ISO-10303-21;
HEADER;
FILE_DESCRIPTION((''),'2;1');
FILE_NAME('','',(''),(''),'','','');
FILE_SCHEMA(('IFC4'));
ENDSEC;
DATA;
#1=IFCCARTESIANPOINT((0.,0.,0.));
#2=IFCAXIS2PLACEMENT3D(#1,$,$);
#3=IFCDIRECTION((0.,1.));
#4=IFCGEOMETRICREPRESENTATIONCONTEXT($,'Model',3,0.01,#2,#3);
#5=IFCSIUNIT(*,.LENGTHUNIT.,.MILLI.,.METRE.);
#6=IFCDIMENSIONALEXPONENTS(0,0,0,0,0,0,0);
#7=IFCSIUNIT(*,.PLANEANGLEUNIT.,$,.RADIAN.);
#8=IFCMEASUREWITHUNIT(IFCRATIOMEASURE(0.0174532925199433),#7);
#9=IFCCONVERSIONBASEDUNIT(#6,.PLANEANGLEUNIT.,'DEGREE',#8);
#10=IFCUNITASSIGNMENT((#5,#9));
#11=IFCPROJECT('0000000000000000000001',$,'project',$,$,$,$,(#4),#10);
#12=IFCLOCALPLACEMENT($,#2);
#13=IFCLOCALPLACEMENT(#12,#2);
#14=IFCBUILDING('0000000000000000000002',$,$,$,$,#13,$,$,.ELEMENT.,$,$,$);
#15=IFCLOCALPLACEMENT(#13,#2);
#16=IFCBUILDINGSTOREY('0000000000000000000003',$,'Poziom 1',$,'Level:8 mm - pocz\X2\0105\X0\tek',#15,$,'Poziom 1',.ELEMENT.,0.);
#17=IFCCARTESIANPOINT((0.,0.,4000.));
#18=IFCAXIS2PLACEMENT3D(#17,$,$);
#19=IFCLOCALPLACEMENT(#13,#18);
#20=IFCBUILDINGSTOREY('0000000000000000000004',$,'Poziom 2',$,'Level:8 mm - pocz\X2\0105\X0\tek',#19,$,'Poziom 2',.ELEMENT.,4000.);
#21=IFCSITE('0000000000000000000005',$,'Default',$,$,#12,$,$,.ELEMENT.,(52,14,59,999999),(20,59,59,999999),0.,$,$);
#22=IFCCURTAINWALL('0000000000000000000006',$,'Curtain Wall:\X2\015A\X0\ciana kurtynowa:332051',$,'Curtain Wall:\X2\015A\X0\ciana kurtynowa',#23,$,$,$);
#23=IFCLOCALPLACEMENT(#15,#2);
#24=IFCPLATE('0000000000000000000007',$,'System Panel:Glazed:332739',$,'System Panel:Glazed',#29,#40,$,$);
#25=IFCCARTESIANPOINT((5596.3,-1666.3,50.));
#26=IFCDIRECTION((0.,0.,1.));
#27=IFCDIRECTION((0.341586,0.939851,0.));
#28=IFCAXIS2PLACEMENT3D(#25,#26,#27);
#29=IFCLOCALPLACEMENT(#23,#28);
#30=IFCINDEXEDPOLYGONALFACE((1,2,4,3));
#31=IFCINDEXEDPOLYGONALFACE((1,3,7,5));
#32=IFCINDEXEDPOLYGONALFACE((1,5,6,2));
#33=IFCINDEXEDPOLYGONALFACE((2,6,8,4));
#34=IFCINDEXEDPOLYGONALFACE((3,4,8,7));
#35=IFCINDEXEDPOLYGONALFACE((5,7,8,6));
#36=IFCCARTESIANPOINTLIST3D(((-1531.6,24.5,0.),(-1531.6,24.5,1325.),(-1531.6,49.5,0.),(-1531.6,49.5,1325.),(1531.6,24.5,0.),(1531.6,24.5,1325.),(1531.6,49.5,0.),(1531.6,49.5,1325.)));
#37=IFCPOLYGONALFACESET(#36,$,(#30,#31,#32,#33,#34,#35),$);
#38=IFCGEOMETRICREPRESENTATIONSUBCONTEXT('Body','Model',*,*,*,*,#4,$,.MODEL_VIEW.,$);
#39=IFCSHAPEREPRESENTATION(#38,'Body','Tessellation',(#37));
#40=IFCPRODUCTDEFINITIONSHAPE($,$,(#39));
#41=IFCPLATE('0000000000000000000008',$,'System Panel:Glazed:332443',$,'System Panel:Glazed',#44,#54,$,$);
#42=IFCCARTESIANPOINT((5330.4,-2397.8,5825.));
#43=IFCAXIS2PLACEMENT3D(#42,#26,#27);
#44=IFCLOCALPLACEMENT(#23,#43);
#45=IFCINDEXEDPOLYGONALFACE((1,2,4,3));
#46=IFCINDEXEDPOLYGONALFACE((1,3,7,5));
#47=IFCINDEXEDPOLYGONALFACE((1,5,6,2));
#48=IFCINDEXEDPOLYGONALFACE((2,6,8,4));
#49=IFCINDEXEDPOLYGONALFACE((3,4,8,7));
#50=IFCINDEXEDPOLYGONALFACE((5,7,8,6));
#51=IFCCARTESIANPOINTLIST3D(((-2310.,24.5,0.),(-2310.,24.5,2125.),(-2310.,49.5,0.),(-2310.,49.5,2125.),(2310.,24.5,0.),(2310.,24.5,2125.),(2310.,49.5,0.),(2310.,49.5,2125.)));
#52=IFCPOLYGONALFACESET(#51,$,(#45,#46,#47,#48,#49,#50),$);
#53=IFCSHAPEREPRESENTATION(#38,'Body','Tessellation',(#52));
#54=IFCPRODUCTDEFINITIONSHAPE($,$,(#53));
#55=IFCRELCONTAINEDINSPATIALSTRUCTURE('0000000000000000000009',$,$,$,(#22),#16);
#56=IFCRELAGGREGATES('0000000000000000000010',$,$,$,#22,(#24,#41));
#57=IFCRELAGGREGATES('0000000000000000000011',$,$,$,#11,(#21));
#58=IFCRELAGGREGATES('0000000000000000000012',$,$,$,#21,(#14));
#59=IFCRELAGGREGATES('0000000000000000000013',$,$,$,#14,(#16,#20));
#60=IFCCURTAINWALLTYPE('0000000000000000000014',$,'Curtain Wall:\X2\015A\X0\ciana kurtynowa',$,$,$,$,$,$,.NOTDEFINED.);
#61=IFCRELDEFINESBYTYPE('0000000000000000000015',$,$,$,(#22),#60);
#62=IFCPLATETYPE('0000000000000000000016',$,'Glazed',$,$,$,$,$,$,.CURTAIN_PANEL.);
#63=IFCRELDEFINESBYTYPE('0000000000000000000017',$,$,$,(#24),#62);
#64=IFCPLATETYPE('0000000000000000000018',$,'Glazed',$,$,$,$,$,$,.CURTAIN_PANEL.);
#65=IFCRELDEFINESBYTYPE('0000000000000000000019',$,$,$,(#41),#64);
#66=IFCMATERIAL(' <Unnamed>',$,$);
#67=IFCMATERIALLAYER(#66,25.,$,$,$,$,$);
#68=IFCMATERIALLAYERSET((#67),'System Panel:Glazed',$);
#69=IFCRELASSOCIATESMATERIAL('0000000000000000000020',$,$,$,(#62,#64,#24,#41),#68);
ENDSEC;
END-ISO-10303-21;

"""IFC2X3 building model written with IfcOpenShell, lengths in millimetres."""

from ifc_helpers import new_model, entity, si_unit, converted_unit, direction, frame, frame_2d, origin, place, context, subcontext, project, spatial, rectangle, extrude, source, transform, mapped, material, layer, layer_set, layer_usage, type_object, type_shapes, element, aggregate, save


model = new_model("IFC2X3")

# Units and contexts
model_context = context("Model", 3, precision=0.01, world=origin(), true_north=direction((0.0, 1.0)))
body_context = subcontext(model_context, "Body", "Model", "MODEL_VIEW")
ifc_project = project(units=[si_unit("LENGTHUNIT", "METRE", prefix="MILLI"), converted_unit("PLANEANGLEUNIT", "DEGREE", entity("IfcRatioMeasure", 0.0174532925199433), si_unit("PLANEANGLEUNIT", "RADIAN"), dimensions=[0, 0, 0, 0, 0, 0, 0])], contexts=[model_context])

# Site, building, storey
site_placement = place(None, origin())
site = spatial("IfcSite", under=ifc_project, at=site_placement, Name="Default", CompositionType="ELEMENT", RefLatitude=(52, 14, 59, 999999), RefLongitude=(20, 59, 59, 999999), RefElevation=0.0)
building_placement = place(site_placement, origin())
building = spatial("IfcBuilding", under=site, at=building_placement, CompositionType="ELEMENT")
storey_1_placement = place(building_placement, origin())
storey_1 = spatial("IfcBuildingStorey", under=building, at=storey_1_placement, Name="Poziom 1", ObjectType="Level:8 mm - początek", LongName="Poziom 1", CompositionType="ELEMENT", Elevation=0.0)

# Curtain wall
curtain_wall_type = type_object("IfcCurtainWallType", Name="Curtain Wall:Ściana kurtynowa", PredefinedType="NOTDEFINED")
curtain_wall_placement = place(storey_1_placement, origin())
curtain_wall = element("IfcCurtainWall", 1, at=curtain_wall_placement, inside=storey_1, type_object=curtain_wall_type, Name="Curtain Wall:Ściana kurtynowa:332051", ObjectType="Curtain Wall:Ściana kurtynowa")

# Plates
ifc_material_1 = material(Name=" <Unnamed>")
ifc_layer_1 = layer(ifc_material_1, 25.0)
ifc_layer_set_1 = layer_set([ifc_layer_1], Name="System Panel:Glazed")
ifc_layer_usage_1 = layer_usage(ifc_layer_set_1, "AXIS3", "POSITIVE", 0.1)
plate_type_1 = type_object("IfcPlateType", Name="Glazed", PredefinedType="CURTAIN_PANEL", material=ifc_layer_set_1)
shared_shape_1 = source(origin(), body_context, "Body", "SweptSolid", [
    extrude(rectangle(XDim=1325.0, YDim=3063.3, at=frame_2d((0.0, -194.6), x_axis=(1.0, 0.0))), frame((194.6, 24.5, 662.5), z_axis=(0.0, 1.0, 0.0), x_axis=(0.0, 0.0, 1.0)), (0.0, 0.0, 1.0), 25.0),
])
type_shapes(plate_type_1, [shared_shape_1])
plate_1_placement = place(curtain_wall_placement, frame((5596.3, -1666.3, 50.0), z_axis=(0.0, 0.0, 1.0), x_axis=(0.341586, 0.939851, 0.0)))
plate_1 = element("IfcPlate", 2, at=plate_1_placement, type_object=plate_type_1, material=ifc_layer_usage_1, Name="System Panel:Glazed:332739", ObjectType="System Panel:Glazed", context=body_context, shape_type="MappedRepresentation", body=[
    mapped(shared_shape_1, transform((0.0, 0.0, 0.0), scale=1.0)),
])
ifc_layer_usage_2 = layer_usage(ifc_layer_set_1, "AXIS3", "POSITIVE", 0.1)
plate_type_2 = type_object("IfcPlateType", Name="Glazed", PredefinedType="CURTAIN_PANEL", material=ifc_layer_set_1)
shared_shape_2 = source(origin(), body_context, "Body", "SweptSolid", [
    extrude(rectangle(XDim=2125.0, YDim=4619.9, at=frame_2d((0.0, -311.3), x_axis=(1.0, 0.0))), frame((311.3, 24.5, 1062.5), z_axis=(0.0, 1.0, 0.0), x_axis=(0.0, 0.0, 1.0)), (0.0, 0.0, 1.0), 25.0),
])
type_shapes(plate_type_2, [shared_shape_2])
plate_2_placement = place(curtain_wall_placement, frame((5330.4, -2397.8, 5825.0), z_axis=(0.0, 0.0, 1.0), x_axis=(0.341586, 0.939851, 0.0)))
plate_2 = element("IfcPlate", 3, at=plate_2_placement, type_object=plate_type_2, material=ifc_layer_usage_2, Name="System Panel:Glazed:332443", ObjectType="System Panel:Glazed", context=body_context, shape_type="MappedRepresentation", body=[
    mapped(shared_shape_2, transform((0.0, 0.0, 0.0), scale=1.0)),
])
aggregate(curtain_wall, [plate_1, plate_2])

# Shared definitions
storey_2_placement = place(building_placement, frame((0.0, 0.0, 4000.0)))
storey_2 = spatial("IfcBuildingStorey", under=building, at=storey_2_placement, Name="Poziom 2", ObjectType="Level:8 mm - początek", LongName="Poziom 2", CompositionType="ELEMENT", Elevation=4000.0)

save(model, "model.ifc")
